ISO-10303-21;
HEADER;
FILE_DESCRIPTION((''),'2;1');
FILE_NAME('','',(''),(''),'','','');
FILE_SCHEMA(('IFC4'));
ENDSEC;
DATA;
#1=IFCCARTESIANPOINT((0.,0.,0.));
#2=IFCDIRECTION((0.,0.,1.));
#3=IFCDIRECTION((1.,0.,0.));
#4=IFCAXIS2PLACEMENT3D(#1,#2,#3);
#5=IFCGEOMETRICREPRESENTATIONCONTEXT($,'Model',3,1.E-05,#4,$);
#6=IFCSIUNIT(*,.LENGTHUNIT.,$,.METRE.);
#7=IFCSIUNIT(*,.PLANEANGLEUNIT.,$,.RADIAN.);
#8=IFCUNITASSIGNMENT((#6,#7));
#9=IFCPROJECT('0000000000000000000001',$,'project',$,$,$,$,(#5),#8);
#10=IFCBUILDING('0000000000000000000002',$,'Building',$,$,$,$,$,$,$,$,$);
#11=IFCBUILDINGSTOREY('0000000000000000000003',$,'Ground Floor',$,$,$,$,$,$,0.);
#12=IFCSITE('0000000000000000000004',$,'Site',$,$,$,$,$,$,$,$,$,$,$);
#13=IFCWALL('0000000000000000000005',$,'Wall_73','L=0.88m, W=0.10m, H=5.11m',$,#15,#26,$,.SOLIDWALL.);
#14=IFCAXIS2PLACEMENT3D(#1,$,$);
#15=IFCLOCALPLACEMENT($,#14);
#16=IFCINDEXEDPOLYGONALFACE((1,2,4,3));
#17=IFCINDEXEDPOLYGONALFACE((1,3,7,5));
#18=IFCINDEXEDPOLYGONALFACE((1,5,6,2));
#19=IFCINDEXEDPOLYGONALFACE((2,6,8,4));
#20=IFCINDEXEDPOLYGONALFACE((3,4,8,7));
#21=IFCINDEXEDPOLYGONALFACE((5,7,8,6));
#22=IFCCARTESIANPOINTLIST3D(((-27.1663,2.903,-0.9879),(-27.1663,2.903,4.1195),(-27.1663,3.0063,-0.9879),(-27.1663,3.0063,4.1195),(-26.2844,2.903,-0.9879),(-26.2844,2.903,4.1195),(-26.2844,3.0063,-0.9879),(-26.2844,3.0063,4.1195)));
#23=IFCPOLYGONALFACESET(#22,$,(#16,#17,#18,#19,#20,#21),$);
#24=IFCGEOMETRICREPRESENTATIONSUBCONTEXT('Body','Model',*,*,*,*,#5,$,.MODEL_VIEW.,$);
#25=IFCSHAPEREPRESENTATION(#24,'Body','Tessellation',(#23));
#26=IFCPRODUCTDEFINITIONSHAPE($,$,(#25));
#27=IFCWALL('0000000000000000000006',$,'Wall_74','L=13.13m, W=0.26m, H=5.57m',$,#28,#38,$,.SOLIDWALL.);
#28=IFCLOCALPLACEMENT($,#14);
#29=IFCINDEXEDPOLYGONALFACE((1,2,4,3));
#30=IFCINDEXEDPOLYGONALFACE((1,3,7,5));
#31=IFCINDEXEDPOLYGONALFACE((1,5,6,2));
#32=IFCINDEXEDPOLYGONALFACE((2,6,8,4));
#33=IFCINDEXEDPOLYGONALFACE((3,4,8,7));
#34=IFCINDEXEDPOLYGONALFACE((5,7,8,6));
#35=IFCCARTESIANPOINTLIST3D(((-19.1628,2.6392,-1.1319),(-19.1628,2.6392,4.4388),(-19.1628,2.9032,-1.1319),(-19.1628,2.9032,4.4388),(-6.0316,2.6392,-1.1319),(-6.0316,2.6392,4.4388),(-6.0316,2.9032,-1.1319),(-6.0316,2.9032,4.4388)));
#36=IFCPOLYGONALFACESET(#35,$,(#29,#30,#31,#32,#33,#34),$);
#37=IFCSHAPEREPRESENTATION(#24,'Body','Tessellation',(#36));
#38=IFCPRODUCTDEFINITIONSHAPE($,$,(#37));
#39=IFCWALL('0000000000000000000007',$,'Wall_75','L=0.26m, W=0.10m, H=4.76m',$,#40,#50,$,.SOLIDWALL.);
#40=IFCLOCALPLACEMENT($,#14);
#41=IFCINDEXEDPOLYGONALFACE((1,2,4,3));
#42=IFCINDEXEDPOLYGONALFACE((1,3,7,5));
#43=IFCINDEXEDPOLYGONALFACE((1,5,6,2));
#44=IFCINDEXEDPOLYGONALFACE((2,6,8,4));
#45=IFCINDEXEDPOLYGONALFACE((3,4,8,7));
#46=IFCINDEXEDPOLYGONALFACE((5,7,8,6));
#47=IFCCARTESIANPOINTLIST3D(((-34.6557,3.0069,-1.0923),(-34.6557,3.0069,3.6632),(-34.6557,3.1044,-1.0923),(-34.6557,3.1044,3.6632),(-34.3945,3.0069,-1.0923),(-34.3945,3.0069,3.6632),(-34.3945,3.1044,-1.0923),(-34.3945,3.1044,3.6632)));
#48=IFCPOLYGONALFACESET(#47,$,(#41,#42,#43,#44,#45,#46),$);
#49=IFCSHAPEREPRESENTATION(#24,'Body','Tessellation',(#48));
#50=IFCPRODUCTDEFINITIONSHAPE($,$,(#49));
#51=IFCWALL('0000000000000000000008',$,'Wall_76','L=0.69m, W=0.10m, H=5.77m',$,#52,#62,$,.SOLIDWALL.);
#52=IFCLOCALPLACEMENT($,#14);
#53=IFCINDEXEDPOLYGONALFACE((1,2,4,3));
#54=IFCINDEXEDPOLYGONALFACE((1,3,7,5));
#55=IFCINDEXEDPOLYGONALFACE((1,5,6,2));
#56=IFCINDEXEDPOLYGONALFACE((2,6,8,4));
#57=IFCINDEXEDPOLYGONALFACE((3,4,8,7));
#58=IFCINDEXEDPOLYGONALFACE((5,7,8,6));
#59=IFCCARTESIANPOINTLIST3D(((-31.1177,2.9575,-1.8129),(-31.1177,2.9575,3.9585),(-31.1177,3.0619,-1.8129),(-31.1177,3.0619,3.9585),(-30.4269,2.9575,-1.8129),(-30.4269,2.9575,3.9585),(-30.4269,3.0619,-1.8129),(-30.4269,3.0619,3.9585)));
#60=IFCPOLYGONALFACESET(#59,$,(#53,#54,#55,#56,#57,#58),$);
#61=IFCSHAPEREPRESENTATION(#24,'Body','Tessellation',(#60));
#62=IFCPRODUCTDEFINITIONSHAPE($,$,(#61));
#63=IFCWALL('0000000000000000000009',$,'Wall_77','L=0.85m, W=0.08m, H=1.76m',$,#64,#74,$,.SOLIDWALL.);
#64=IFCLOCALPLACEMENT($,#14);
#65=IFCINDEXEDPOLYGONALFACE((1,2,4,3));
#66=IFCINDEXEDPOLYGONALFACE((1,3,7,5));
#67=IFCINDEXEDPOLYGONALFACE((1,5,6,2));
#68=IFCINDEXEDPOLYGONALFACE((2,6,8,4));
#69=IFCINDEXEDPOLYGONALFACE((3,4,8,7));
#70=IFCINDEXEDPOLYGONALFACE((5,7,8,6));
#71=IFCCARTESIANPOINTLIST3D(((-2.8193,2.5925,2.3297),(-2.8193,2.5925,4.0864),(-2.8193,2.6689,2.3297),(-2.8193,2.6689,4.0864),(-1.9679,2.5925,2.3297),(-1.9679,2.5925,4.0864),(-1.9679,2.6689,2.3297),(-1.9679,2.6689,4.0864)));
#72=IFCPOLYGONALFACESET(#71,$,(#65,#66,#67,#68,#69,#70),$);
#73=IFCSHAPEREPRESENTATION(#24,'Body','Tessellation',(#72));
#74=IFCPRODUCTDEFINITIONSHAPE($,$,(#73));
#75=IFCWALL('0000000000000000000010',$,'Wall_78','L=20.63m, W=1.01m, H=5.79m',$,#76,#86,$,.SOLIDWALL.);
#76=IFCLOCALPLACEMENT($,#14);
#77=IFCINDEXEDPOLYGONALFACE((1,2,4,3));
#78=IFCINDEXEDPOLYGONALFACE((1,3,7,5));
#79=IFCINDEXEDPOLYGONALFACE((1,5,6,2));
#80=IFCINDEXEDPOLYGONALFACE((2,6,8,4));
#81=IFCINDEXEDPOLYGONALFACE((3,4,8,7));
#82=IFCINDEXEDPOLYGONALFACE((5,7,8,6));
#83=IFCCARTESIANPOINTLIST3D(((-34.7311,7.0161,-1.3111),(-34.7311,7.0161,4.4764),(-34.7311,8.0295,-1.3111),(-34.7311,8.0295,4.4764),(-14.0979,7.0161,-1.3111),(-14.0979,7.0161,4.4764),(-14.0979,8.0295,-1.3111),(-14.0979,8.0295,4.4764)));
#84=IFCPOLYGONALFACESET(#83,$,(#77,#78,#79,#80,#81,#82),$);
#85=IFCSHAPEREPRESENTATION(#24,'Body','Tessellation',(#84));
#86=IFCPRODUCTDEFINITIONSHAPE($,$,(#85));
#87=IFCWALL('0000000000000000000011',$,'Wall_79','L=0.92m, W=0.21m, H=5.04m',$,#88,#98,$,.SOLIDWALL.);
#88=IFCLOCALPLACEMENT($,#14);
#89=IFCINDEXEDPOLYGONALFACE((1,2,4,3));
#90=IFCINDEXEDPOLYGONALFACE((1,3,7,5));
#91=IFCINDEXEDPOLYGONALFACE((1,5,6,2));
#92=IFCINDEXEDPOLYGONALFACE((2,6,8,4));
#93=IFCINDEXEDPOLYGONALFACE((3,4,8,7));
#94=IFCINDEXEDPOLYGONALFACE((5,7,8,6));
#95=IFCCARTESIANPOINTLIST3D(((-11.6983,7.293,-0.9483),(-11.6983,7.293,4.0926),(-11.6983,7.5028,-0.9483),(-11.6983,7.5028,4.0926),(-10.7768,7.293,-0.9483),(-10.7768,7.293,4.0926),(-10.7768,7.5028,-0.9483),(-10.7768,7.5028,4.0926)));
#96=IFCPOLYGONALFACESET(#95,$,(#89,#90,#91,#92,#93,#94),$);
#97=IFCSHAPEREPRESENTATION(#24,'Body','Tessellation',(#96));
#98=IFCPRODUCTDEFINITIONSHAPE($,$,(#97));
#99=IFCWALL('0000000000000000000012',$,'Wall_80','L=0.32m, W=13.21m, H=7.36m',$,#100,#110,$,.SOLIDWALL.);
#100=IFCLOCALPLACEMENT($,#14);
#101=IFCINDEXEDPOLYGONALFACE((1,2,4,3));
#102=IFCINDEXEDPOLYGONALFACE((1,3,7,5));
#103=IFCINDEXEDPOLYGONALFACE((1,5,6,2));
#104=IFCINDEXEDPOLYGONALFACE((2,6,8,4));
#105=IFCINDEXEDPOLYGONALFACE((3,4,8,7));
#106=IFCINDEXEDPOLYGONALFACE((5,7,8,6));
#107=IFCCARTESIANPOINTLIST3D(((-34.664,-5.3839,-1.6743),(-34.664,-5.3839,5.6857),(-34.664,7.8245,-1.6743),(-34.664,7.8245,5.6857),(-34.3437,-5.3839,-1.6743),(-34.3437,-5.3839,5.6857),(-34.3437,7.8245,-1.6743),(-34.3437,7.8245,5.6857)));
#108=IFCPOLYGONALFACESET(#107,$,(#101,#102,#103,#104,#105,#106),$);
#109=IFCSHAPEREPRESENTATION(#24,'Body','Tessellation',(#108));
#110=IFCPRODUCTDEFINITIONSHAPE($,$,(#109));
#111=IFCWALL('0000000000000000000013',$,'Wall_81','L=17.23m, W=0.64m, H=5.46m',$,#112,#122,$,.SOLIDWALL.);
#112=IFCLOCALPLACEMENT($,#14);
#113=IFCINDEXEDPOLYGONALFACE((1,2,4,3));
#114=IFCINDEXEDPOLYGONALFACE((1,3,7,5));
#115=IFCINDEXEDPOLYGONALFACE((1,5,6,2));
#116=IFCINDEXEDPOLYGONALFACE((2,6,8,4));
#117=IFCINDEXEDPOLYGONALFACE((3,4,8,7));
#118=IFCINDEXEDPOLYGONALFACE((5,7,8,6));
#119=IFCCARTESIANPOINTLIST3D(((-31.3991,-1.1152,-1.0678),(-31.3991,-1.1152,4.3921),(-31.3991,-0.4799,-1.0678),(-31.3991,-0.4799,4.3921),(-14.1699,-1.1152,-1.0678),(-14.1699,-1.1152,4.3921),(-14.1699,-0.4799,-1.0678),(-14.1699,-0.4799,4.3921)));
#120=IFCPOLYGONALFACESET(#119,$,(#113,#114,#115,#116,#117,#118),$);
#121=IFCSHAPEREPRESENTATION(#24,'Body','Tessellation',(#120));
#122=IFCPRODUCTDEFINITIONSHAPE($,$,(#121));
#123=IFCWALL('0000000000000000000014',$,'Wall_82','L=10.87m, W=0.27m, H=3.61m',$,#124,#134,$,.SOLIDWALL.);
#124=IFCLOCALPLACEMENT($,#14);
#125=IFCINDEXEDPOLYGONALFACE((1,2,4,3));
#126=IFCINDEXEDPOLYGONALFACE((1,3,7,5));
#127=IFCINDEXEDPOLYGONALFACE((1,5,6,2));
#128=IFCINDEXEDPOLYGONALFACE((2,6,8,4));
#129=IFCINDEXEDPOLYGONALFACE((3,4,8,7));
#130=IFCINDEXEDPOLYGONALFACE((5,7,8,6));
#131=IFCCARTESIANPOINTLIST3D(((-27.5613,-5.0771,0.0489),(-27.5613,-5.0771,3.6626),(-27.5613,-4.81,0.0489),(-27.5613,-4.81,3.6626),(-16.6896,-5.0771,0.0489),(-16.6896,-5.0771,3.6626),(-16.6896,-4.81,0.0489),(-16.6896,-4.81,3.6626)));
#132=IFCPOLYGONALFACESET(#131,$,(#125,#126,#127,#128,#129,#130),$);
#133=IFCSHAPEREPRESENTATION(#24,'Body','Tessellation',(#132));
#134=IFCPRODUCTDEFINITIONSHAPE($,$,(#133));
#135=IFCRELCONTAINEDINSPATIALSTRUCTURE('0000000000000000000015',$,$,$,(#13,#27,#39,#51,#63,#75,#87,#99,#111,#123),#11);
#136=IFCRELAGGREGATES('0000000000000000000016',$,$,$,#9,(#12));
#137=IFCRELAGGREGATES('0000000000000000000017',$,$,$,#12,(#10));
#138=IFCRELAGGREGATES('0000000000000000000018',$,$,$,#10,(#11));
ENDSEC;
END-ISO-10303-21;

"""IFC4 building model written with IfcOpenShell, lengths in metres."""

from ifc_helpers import new_model, si_unit, frame, origin_with_axes, origin_2d, context, subcontext, project, spatial, rectangle, extrude, element, save


model = new_model("IFC4")

# Units and contexts
model_context = context("Model", 3, precision=1e-05, world=origin_with_axes())
body_context = subcontext(model_context, "Body", "Model", "MODEL_VIEW")
ifc_project = project(units=[si_unit("LENGTHUNIT", "METRE"), si_unit("PLANEANGLEUNIT", "RADIAN")], contexts=[model_context])

# Site, building, storey
site = spatial("IfcSite", under=ifc_project, Name="Site")
building = spatial("IfcBuilding", under=site, Name="Building")
storey = spatial("IfcBuildingStorey", under=building, Name="Ground Floor", Elevation=0.0)

# Walls
element("IfcWall", 1, inside=storey, Name="Wall_73", Description="L=0.88m, W=0.10m, H=5.11m", PredefinedType="SOLIDWALL", context=body_context, shape_type="SweptSolid", body=[
    extrude(rectangle(XDim=0.8819, YDim=0.1033, at=origin_2d()), frame((-26.7254, 2.9547, -0.9879), z_axis=(0.0, 0.0, 1.0), x_axis=(1.0, 0.0, 0.0)), (0.0, 0.0, 1.0), 5.1075),
])
element("IfcWall", 2, inside=storey, Name="Wall_74", Description="L=13.13m, W=0.26m, H=5.57m", PredefinedType="SOLIDWALL", context=body_context, shape_type="SweptSolid", body=[
    extrude(rectangle(XDim=13.1312, YDim=0.264, at=origin_2d()), frame((-12.5972, 2.7712, -1.1319), z_axis=(0.0, 0.0, 1.0), x_axis=(1.0, 0.0, 0.0)), (0.0, 0.0, 1.0), 5.5707),
])
element("IfcWall", 3, inside=storey, Name="Wall_75", Description="L=0.26m, W=0.10m, H=4.76m", PredefinedType="SOLIDWALL", context=body_context, shape_type="SweptSolid", body=[
    extrude(rectangle(XDim=0.2612, YDim=0.0975, at=origin_2d()), frame((-34.5251, 3.0556, -1.0923), z_axis=(0.0, 0.0, 1.0), x_axis=(1.0, 0.0, 0.0)), (0.0, 0.0, 1.0), 4.7555),
])
element("IfcWall", 4, inside=storey, Name="Wall_76", Description="L=0.69m, W=0.10m, H=5.77m", PredefinedType="SOLIDWALL", context=body_context, shape_type="SweptSolid", body=[
    extrude(rectangle(XDim=0.6907, YDim=0.1044, at=origin_2d()), frame((-30.7723, 3.0097, -1.8129), z_axis=(0.0, 0.0, 1.0), x_axis=(1.0, 0.0, 0.0)), (0.0, 0.0, 1.0), 5.7715),
])
element("IfcWall", 5, inside=storey, Name="Wall_77", Description="L=0.85m, W=0.08m, H=1.76m", PredefinedType="SOLIDWALL", context=body_context, shape_type="SweptSolid", body=[
    extrude(rectangle(XDim=0.8514, YDim=0.0764, at=origin_2d()), frame((-2.3936, 2.6307, 2.3297), z_axis=(0.0, 0.0, 1.0), x_axis=(1.0, 0.0, 0.0)), (0.0, 0.0, 1.0), 1.7568),
])
element("IfcWall", 6, inside=storey, Name="Wall_78", Description="L=20.63m, W=1.01m, H=5.79m", PredefinedType="SOLIDWALL", context=body_context, shape_type="SweptSolid", body=[
    extrude(rectangle(XDim=20.6332, YDim=1.0133, at=origin_2d()), frame((-24.4145, 7.5228, -1.3111), z_axis=(0.0, 0.0, 1.0), x_axis=(1.0, 0.0, 0.0)), (0.0, 0.0, 1.0), 5.7875),
])
element("IfcWall", 7, inside=storey, Name="Wall_79", Description="L=0.92m, W=0.21m, H=5.04m", PredefinedType="SOLIDWALL", context=body_context, shape_type="SweptSolid", body=[
    extrude(rectangle(XDim=0.9215, YDim=0.2097, at=origin_2d()), frame((-11.2375, 7.3979, -0.9483), z_axis=(0.0, 0.0, 1.0), x_axis=(1.0, 0.0, 0.0)), (0.0, 0.0, 1.0), 5.0409),
])
element("IfcWall", 8, inside=storey, Name="Wall_80", Description="L=0.32m, W=13.21m, H=7.36m", PredefinedType="SOLIDWALL", context=body_context, shape_type="SweptSolid", body=[
    extrude(rectangle(XDim=0.3203, YDim=13.2084, at=origin_2d()), frame((-34.5038, 1.2203, -1.6743), z_axis=(0.0, 0.0, 1.0), x_axis=(1.0, 0.0, 0.0)), (0.0, 0.0, 1.0), 7.36),
])
element("IfcWall", 9, inside=storey, Name="Wall_81", Description="L=17.23m, W=0.64m, H=5.46m", PredefinedType="SOLIDWALL", context=body_context, shape_type="SweptSolid", body=[
    extrude(rectangle(XDim=17.2292, YDim=0.6353, at=origin_2d()), frame((-22.7845, -0.7975, -1.0678), z_axis=(0.0, 0.0, 1.0), x_axis=(1.0, 0.0, 0.0)), (0.0, 0.0, 1.0), 5.4599),
])
element("IfcWall", 10, inside=storey, Name="Wall_82", Description="L=10.87m, W=0.27m, H=3.61m", PredefinedType="SOLIDWALL", context=body_context, shape_type="SweptSolid", body=[
    extrude(rectangle(XDim=10.8717, YDim=0.267, at=origin_2d()), frame((-22.1254, -4.9436, 0.0489), z_axis=(0.0, 0.0, 1.0), x_axis=(1.0, 0.0, 0.0)), (0.0, 0.0, 1.0), 3.6137),
])

save(model, "model.ifc")
